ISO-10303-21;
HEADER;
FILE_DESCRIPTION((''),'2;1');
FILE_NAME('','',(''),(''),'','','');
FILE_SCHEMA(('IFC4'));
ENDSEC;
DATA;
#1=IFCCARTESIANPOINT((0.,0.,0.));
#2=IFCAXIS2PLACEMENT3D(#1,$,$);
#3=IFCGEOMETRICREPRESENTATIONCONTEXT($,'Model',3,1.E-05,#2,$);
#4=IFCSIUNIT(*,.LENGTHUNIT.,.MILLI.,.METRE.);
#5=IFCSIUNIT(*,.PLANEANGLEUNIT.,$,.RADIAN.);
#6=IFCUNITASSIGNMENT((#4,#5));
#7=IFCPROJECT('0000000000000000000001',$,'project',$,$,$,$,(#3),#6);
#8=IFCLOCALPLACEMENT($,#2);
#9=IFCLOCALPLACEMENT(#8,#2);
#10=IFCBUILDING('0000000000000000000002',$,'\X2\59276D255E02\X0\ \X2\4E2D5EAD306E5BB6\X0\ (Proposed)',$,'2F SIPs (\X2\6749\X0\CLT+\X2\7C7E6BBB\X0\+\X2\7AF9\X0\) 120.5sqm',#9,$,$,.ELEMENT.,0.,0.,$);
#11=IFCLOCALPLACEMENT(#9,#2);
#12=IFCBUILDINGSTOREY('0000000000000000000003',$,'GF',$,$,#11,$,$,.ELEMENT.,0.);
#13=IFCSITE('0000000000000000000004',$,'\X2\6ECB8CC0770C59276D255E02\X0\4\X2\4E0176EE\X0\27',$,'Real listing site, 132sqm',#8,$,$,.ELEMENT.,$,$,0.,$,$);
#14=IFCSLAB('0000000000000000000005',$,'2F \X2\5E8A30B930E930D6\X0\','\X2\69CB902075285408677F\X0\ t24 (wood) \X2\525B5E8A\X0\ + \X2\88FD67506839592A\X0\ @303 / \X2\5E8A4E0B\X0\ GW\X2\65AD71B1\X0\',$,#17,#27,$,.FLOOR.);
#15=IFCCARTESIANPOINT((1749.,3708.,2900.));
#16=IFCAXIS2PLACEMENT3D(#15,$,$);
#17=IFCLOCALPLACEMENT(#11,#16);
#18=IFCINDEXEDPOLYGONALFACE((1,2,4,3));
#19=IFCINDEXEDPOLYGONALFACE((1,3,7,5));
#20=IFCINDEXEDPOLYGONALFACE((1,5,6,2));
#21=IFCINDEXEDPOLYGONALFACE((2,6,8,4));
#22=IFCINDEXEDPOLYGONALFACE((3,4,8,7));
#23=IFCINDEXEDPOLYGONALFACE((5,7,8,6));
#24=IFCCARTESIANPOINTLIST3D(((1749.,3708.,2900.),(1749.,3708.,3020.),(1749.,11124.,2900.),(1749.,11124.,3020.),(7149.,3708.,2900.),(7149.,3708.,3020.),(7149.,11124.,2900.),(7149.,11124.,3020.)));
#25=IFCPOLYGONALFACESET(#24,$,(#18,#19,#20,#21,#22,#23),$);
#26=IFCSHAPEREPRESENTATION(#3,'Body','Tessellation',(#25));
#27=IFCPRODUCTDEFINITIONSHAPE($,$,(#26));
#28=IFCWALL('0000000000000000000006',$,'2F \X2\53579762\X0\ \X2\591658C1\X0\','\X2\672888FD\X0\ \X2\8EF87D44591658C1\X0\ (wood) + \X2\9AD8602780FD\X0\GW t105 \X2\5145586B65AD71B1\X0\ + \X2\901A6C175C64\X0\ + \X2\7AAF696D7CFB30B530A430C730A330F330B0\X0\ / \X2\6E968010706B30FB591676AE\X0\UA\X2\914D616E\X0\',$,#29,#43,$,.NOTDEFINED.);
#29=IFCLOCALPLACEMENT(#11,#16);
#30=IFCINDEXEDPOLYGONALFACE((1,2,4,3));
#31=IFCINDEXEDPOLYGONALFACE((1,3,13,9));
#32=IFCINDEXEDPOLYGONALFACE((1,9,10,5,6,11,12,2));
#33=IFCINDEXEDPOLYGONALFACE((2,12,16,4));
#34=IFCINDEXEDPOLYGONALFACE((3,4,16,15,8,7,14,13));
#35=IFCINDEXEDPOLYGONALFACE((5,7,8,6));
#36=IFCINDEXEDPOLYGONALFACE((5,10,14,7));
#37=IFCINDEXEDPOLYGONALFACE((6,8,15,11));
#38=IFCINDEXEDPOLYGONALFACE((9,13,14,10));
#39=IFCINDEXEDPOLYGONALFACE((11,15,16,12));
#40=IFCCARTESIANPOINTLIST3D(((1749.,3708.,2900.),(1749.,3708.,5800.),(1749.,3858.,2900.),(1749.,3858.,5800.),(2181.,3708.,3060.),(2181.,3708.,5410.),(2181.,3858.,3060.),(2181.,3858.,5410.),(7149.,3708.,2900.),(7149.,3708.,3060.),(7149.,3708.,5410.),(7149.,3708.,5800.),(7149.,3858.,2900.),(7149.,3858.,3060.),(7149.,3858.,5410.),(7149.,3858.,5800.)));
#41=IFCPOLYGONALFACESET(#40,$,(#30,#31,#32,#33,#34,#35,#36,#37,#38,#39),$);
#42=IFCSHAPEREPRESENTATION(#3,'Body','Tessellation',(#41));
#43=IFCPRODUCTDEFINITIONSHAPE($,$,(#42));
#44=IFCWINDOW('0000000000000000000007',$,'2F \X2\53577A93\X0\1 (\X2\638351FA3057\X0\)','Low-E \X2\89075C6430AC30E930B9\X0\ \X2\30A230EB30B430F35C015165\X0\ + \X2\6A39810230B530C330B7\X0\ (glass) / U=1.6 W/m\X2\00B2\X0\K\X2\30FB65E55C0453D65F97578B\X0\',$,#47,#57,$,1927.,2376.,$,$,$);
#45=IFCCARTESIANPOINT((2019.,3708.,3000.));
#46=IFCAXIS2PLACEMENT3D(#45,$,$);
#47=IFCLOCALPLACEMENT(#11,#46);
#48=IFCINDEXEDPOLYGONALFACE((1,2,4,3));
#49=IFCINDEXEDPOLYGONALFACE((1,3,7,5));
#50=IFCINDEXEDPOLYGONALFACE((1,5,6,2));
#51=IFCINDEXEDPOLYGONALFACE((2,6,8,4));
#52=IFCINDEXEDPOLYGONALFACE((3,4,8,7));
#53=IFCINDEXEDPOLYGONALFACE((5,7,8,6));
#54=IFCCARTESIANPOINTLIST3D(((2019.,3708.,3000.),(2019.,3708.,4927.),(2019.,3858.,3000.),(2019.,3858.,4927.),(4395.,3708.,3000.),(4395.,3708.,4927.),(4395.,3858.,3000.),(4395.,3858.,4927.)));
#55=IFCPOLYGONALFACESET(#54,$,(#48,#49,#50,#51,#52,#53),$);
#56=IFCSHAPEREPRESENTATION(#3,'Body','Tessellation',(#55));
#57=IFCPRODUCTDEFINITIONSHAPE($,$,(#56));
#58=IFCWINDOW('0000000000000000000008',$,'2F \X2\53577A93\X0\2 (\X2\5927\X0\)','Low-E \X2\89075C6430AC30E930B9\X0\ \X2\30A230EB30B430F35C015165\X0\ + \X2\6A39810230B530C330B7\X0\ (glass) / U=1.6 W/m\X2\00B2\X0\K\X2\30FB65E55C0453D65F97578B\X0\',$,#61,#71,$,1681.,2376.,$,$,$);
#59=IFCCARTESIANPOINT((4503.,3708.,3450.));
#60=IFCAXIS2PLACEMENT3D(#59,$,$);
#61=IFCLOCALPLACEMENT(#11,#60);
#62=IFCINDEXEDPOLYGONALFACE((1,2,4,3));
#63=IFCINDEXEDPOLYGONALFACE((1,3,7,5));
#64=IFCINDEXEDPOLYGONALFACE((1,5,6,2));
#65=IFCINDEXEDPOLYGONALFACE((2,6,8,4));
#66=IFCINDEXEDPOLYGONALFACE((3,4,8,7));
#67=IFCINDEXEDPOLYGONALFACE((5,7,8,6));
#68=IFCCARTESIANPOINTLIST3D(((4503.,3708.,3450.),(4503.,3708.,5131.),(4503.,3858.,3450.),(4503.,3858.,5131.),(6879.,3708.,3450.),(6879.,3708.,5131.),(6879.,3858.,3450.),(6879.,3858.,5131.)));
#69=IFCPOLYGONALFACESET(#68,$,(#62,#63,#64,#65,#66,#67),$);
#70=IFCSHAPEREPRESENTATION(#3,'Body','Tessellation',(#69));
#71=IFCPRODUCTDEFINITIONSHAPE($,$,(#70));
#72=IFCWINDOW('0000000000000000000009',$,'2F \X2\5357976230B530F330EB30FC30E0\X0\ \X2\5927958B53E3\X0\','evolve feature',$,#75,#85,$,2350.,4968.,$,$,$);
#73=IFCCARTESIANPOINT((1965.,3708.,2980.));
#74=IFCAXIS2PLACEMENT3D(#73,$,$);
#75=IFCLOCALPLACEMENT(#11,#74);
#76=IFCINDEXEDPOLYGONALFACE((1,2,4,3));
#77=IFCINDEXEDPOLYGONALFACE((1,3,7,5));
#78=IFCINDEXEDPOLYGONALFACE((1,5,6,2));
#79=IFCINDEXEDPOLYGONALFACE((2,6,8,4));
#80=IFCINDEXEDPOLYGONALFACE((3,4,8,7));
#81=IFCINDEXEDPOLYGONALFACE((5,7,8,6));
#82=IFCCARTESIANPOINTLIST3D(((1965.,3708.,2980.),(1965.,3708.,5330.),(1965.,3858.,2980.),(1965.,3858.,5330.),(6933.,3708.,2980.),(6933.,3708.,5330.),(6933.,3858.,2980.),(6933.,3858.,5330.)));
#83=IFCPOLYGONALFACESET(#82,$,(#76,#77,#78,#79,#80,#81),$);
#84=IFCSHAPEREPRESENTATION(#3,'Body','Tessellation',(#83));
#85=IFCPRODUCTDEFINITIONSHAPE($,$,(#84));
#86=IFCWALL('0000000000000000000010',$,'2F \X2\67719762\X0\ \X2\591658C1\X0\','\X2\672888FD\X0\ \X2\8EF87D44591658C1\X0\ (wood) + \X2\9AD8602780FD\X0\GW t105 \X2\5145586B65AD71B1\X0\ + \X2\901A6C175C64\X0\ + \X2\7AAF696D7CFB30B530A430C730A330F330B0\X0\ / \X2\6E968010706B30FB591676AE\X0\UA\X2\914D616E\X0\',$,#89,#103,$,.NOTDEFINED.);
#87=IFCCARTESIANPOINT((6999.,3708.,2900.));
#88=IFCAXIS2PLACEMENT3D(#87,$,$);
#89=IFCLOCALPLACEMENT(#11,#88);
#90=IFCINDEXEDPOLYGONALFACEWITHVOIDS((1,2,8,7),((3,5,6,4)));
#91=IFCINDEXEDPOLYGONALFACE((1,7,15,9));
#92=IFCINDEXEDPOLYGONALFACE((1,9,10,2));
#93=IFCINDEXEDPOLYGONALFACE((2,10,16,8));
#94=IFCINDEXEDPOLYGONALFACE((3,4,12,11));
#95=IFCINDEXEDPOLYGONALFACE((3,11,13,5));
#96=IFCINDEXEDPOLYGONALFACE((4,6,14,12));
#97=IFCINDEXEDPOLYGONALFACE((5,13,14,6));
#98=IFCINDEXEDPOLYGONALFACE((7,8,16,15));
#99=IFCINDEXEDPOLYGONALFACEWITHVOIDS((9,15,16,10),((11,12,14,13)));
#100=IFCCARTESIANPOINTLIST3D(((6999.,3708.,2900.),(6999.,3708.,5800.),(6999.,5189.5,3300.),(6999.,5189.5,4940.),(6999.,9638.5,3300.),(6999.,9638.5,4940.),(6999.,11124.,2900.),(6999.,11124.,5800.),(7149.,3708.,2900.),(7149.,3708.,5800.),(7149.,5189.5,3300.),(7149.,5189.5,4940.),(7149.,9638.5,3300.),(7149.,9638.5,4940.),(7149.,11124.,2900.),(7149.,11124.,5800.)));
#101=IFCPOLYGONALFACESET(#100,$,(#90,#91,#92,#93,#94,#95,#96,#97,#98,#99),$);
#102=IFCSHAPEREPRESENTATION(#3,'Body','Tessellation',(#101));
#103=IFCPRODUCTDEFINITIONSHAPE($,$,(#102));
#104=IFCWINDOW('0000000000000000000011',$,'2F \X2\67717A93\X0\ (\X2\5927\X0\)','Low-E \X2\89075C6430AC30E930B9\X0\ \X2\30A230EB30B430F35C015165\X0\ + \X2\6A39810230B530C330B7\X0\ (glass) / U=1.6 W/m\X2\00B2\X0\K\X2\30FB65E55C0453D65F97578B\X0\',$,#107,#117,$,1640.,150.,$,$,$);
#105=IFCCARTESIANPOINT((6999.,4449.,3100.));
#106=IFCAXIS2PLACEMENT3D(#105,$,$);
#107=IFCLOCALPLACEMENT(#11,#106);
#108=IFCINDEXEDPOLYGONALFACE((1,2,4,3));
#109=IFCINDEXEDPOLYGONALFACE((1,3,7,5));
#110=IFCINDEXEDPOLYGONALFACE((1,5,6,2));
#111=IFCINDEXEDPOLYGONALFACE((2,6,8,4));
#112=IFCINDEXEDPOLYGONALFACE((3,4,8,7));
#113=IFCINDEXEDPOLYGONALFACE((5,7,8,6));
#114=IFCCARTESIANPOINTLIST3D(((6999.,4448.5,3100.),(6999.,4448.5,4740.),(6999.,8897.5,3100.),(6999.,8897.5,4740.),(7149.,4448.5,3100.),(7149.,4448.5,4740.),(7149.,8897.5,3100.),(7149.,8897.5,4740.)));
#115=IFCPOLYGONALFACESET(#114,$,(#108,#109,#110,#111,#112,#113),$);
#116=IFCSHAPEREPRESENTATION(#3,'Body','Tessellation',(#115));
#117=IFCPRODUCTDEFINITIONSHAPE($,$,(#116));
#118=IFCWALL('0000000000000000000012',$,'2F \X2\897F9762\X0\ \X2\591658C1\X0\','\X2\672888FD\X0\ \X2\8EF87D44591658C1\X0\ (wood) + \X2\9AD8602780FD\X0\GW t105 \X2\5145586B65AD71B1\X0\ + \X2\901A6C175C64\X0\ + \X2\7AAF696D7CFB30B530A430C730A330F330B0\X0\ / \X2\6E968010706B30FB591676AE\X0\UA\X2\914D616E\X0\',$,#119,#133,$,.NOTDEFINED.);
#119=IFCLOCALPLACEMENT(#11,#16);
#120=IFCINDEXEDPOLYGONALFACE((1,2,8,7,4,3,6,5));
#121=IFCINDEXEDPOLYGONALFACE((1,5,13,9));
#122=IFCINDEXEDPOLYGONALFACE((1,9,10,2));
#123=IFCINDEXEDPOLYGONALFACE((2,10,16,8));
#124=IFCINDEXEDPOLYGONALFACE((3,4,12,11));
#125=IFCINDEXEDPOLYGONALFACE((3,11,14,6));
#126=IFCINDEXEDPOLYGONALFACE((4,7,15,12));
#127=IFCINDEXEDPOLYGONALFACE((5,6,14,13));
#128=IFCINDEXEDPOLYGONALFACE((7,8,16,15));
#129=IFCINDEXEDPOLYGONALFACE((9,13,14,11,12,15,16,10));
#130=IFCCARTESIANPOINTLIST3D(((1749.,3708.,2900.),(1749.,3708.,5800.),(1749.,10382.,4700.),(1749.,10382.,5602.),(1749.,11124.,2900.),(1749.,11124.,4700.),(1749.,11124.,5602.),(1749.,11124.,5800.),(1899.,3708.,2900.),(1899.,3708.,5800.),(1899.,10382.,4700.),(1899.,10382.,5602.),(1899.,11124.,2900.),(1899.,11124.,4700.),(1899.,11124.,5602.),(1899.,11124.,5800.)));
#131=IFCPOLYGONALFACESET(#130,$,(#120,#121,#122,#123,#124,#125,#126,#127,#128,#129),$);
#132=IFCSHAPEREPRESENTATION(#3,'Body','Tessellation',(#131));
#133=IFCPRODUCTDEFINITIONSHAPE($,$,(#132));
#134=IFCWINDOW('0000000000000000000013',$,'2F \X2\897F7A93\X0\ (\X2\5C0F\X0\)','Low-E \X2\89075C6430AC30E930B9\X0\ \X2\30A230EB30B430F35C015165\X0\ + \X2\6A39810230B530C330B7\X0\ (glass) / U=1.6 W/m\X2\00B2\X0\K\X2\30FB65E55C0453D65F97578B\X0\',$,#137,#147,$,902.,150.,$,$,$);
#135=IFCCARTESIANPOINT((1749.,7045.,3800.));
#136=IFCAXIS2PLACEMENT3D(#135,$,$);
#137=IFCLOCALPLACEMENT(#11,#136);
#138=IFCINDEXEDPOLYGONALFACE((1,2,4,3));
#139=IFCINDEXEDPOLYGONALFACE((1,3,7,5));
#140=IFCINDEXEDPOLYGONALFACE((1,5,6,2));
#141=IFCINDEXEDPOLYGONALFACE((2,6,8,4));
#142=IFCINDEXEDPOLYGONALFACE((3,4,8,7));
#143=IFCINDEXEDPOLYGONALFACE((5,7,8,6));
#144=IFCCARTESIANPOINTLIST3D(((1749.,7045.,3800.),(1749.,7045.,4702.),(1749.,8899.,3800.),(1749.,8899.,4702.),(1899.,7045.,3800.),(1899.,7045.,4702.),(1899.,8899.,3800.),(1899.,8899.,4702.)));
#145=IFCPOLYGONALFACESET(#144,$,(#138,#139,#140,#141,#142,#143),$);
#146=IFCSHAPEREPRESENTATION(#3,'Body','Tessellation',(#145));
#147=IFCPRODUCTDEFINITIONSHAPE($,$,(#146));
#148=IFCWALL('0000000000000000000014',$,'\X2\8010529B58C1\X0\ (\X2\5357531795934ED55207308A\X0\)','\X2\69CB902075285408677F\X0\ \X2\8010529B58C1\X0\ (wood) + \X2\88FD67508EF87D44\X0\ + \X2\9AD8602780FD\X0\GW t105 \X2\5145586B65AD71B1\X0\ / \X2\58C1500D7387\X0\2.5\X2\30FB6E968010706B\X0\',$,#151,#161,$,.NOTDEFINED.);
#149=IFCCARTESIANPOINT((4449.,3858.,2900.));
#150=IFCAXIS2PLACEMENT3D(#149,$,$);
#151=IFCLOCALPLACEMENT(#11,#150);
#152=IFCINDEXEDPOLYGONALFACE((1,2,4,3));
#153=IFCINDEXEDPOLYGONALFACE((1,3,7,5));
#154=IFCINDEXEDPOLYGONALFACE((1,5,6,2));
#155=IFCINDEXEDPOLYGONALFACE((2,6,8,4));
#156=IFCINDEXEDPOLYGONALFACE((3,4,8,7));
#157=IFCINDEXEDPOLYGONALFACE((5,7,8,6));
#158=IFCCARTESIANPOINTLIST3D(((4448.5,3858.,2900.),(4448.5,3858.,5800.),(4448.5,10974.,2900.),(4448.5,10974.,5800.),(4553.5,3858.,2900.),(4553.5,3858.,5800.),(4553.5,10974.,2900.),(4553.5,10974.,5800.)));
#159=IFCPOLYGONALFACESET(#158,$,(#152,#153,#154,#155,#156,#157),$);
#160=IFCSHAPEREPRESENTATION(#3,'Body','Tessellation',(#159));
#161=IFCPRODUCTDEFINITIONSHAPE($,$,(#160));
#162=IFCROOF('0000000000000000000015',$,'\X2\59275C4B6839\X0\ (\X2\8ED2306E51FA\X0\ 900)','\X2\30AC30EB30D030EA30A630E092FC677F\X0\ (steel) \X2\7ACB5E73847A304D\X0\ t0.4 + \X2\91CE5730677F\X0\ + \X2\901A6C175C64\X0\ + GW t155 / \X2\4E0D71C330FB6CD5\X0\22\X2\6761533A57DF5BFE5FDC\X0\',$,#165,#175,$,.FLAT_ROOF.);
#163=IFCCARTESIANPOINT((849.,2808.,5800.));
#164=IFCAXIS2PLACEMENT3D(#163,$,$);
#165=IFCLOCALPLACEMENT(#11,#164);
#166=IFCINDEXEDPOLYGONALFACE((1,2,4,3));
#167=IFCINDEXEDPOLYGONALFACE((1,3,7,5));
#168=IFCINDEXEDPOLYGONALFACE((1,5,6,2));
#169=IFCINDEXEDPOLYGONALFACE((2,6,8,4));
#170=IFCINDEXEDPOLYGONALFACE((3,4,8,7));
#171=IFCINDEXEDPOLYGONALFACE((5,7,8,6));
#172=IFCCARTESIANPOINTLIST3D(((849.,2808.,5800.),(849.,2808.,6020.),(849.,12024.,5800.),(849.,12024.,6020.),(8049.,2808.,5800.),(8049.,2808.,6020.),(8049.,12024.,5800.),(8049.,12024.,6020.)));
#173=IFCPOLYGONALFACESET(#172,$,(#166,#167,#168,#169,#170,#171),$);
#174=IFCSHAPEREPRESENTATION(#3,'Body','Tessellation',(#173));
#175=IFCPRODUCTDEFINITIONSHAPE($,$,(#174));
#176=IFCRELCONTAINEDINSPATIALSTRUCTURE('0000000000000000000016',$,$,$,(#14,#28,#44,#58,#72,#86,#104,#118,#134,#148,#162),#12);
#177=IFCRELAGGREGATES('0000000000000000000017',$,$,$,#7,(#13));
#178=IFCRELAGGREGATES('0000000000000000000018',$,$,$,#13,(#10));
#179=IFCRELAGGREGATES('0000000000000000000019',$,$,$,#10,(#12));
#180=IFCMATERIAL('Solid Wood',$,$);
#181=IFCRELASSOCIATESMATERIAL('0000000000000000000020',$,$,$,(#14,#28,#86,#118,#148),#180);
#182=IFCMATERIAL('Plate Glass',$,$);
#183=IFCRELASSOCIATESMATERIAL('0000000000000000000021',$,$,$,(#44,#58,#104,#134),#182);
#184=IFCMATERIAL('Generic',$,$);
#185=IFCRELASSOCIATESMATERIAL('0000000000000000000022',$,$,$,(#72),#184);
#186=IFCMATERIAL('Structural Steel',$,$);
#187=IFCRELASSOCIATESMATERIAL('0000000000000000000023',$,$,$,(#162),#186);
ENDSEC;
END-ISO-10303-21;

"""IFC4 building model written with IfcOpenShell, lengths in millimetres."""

from ifc_helpers import new_model, si_unit, frame, frame_2d, origin, place, context, project, spatial, rectangle, extrude, material, element, fill, save


model = new_model("IFC4")

# Units and contexts
model_context = context("Model", 3, precision=1e-05, world=origin())
ifc_project = project(units=[si_unit("LENGTHUNIT", "METRE", prefix="MILLI"), si_unit("PLANEANGLEUNIT", "RADIAN")], contexts=[model_context])

# Site, building, storey
site_placement = place(None, origin())
site = spatial("IfcSite", under=ifc_project, at=site_placement, Name="滋賀県大津市4丁目27", ObjectType="Real listing site, 132sqm", CompositionType="ELEMENT", RefElevation=0.0)
building_placement = place(site_placement, origin())
building = spatial("IfcBuilding", under=site, at=building_placement, Name="大津市 中庭の家 (Proposed)", ObjectType="2F SIPs (杉CLT+籾殻+竹) 120.5sqm", CompositionType="ELEMENT", ElevationOfRefHeight=0.0, ElevationOfTerrain=0.0)
storey_placement = place(building_placement, origin())
storey = spatial("IfcBuildingStorey", under=building, at=storey_placement, Name="GF", CompositionType="ELEMENT", Elevation=0.0)

# Slab
ifc_material_1 = material(Name="Solid Wood")
slab_placement = place(storey_placement, frame((1749.0, 3708.0, 2900.0)))
element("IfcSlab", 1, at=slab_placement, inside=storey, material=ifc_material_1, Name="2F 床スラブ", Description="構造用合板 t24 (wood) 剛床 + 製材根太 @303 / 床下 GW断熱", PredefinedType="FLOOR", context=model_context, shape_type="SweptSolid", body=[
    extrude(rectangle(XDim=5400.0, YDim=7416.0, at=frame_2d((2700.0, 3708.0))), frame((1749.0, 3708.0, 2900.0)), (0.0, 0.0, 1.0), 120.0),
])

# Wall, openings, windows
wall_1_placement = place(storey_placement, frame((1749.0, 3708.0, 2900.0)))
wall_1 = element("IfcWall", 2, at=wall_1_placement, inside=storey, material=ifc_material_1, Name="2F 南面 外壁", Description="木製 軸組外壁 (wood) + 高性能GW t105 充填断熱 + 通気層 + 窯業系サイディング / 準耐火・外皮UA配慮", PredefinedType="NOTDEFINED", context=model_context, shape_type="SweptSolid", body=[
    extrude(rectangle(XDim=5400.0, YDim=150.0, at=frame_2d((2700.0, 75.0))), frame((1749.0, 3708.0, 2900.0)), (0.0, 0.0, 1.0), 2900.0),
])
opening_1_placement = place(storey_placement, frame((2019.0, 3708.0, 3000.0)))
opening_1 = element("IfcOpeningElement", 3, at=opening_1_placement, cuts=wall_1, PredefinedType="NOTDEFINED", context=model_context, shape_type="SweptSolid", body=[
    extrude(rectangle(XDim=2376.0, YDim=150.0, at=frame_2d((1188.0, 75.0))), frame((2019.0, 3708.0, 3000.0)), (0.0, 0.0, 1.0), 1927.0),
])
opening_2_placement = place(storey_placement, frame((4503.0, 3708.0, 3450.0)))
opening_2 = element("IfcOpeningElement", 4, at=opening_2_placement, cuts=wall_1, PredefinedType="NOTDEFINED", context=model_context, shape_type="SweptSolid", body=[
    extrude(rectangle(XDim=2376.0, YDim=150.0, at=frame_2d((1188.0, 75.0))), frame((4503.0, 3708.0, 3450.0)), (0.0, 0.0, 1.0), 1681.0),
])
opening_3_placement = place(storey_placement, frame((1965.0, 3708.0, 2980.0)))
opening_3 = element("IfcOpeningElement", 5, at=opening_3_placement, cuts=wall_1, PredefinedType="NOTDEFINED", context=model_context, shape_type="SweptSolid", body=[
    extrude(rectangle(XDim=4968.0, YDim=150.0, at=frame_2d((2484.0, 75.0))), frame((1965.0, 3708.0, 2980.0)), (0.0, 0.0, 1.0), 2350.0),
])
ifc_material_2 = material(Name="Plate Glass")
window_1_placement = place(storey_placement, frame((2019.0, 3708.0, 3000.0)))
window_1 = element("IfcWindow", 6, at=window_1_placement, inside=storey, material=ifc_material_2, Name="2F 南窓1 (掃出し)", Description="Low-E 複層ガラス アルゴン封入 + 樹脂サッシ (glass) / U=1.6 W/m²K・日射取得型", OverallHeight=1927.0, OverallWidth=2376.0, context=model_context, shape_type="SweptSolid", body=[
    extrude(rectangle(XDim=2376.0, YDim=150.0, at=frame_2d((1188.0, 75.0))), frame((2019.0, 3708.0, 3000.0)), (0.0, 0.0, 1.0), 1927.0),
])
fill(opening_1, window_1)
window_2_placement = place(storey_placement, frame((4503.0, 3708.0, 3450.0)))
window_2 = element("IfcWindow", 7, at=window_2_placement, inside=storey, material=ifc_material_2, Name="2F 南窓2 (大)", Description="Low-E 複層ガラス アルゴン封入 + 樹脂サッシ (glass) / U=1.6 W/m²K・日射取得型", OverallHeight=1681.0, OverallWidth=2376.0, context=model_context, shape_type="SweptSolid", body=[
    extrude(rectangle(XDim=2376.0, YDim=150.0, at=frame_2d((1188.0, 75.0))), frame((4503.0, 3708.0, 3450.0)), (0.0, 0.0, 1.0), 1681.0),
])
fill(opening_2, window_2)
ifc_material_3 = material(Name="Generic")
window_3_placement = place(storey_placement, frame((1965.0, 3708.0, 2980.0)))
window_3 = element("IfcWindow", 8, at=window_3_placement, inside=storey, material=ifc_material_3, Name="2F 南面サンルーム 大開口", Description="evolve feature", OverallHeight=2350.0, OverallWidth=4968.0, context=model_context, shape_type="SweptSolid", body=[
    extrude(rectangle(XDim=4968.0, YDim=150.0, at=frame_2d((2484.0, 75.0))), frame((1965.0, 3708.0, 2980.0)), (0.0, 0.0, 1.0), 2350.0),
])
fill(opening_3, window_3)

# Walls, openings, windows
wall_2_placement = place(storey_placement, frame((6999.0, 3708.0, 2900.0)))
wall_2 = element("IfcWall", 9, at=wall_2_placement, inside=storey, material=ifc_material_1, Name="2F 東面 外壁", Description="木製 軸組外壁 (wood) + 高性能GW t105 充填断熱 + 通気層 + 窯業系サイディング / 準耐火・外皮UA配慮", PredefinedType="NOTDEFINED", context=model_context, shape_type="SweptSolid", body=[
    extrude(rectangle(XDim=150.0, YDim=7416.0, at=frame_2d((75.0, 3708.0))), frame((6999.0, 3708.0, 2900.0)), (0.0, 0.0, 1.0), 2900.0),
])
opening_4_placement = place(storey_placement, frame((6999.0, 4449.0, 3100.0)))
opening_4 = element("IfcOpeningElement", 10, at=opening_4_placement, cuts=wall_2, PredefinedType="NOTDEFINED", context=model_context, shape_type="SweptSolid", body=[
    extrude(rectangle(XDim=150.0, YDim=4449.0, at=frame_2d((75.0, 2224.0))), frame((6999.0, 4449.0, 3100.0)), (0.0, 0.0, 1.0), 1640.0),
])
window_4_placement = place(storey_placement, frame((6999.0, 4449.0, 3100.0)))
window_4 = element("IfcWindow", 11, at=window_4_placement, inside=storey, material=ifc_material_2, Name="2F 東窓 (大)", Description="Low-E 複層ガラス アルゴン封入 + 樹脂サッシ (glass) / U=1.6 W/m²K・日射取得型", OverallHeight=1640.0, OverallWidth=150.0, context=model_context, shape_type="SweptSolid", body=[
    extrude(rectangle(XDim=150.0, YDim=4449.0, at=frame_2d((75.0, 2224.0))), frame((6999.0, 4449.0, 3100.0)), (0.0, 0.0, 1.0), 1640.0),
])
fill(opening_4, window_4)
wall_3_placement = place(storey_placement, frame((1749.0, 3708.0, 2900.0)))
wall_3 = element("IfcWall", 12, at=wall_3_placement, inside=storey, material=ifc_material_1, Name="2F 西面 外壁", Description="木製 軸組外壁 (wood) + 高性能GW t105 充填断熱 + 通気層 + 窯業系サイディング / 準耐火・外皮UA配慮", PredefinedType="NOTDEFINED", context=model_context, shape_type="SweptSolid", body=[
    extrude(rectangle(XDim=150.0, YDim=7416.0, at=frame_2d((75.0, 3708.0))), frame((1749.0, 3708.0, 2900.0)), (0.0, 0.0, 1.0), 2900.0),
])
opening_5_placement = place(storey_placement, frame((1749.0, 7045.0, 3800.0)))
opening_5 = element("IfcOpeningElement", 13, at=opening_5_placement, cuts=wall_3, PredefinedType="NOTDEFINED", context=model_context, shape_type="SweptSolid", body=[
    extrude(rectangle(XDim=150.0, YDim=1854.0, at=frame_2d((75.0, 927.0))), frame((1749.0, 7045.0, 3800.0)), (0.0, 0.0, 1.0), 902.0),
])
window_5_placement = place(storey_placement, frame((1749.0, 7045.0, 3800.0)))
window_5 = element("IfcWindow", 14, at=window_5_placement, inside=storey, material=ifc_material_2, Name="2F 西窓 (小)", Description="Low-E 複層ガラス アルゴン封入 + 樹脂サッシ (glass) / U=1.6 W/m²K・日射取得型", OverallHeight=902.0, OverallWidth=150.0, context=model_context, shape_type="SweptSolid", body=[
    extrude(rectangle(XDim=150.0, YDim=1854.0, at=frame_2d((75.0, 927.0))), frame((1749.0, 7045.0, 3800.0)), (0.0, 0.0, 1.0), 902.0),
])
fill(opening_5, window_5)

# Wall
wall_4_placement = place(storey_placement, frame((4449.0, 3858.0, 2900.0)))
element("IfcWall", 15, at=wall_4_placement, inside=storey, material=ifc_material_1, Name="耐力壁 (南北間仕切り)", Description="構造用合板 耐力壁 (wood) + 製材軸組 + 高性能GW t105 充填断熱 / 壁倍率2.5・準耐火", PredefinedType="NOTDEFINED", context=model_context, shape_type="SweptSolid", body=[
    extrude(rectangle(XDim=105.0, YDim=7116.0, at=frame_2d((52.0, 3558.0))), frame((4449.0, 3858.0, 2900.0)), (0.0, 0.0, 1.0), 2900.0),
])

# Roof
ifc_material_4 = material(Name="Structural Steel")
roof_1_placement = place(storey_placement, frame((849.0, 2808.0, 5800.0)))
element("IfcRoof", 16, at=roof_1_placement, inside=storey, material=ifc_material_4, Name="大屋根 (軒の出 900)", Description="ガルバリウム鋼板 (steel) 立平葺き t0.4 + 野地板 + 通気層 + GW t155 / 不燃・法22条区域対応", PredefinedType="FLAT_ROOF", context=model_context, shape_type="SweptSolid", body=[
    extrude(rectangle(XDim=7200.0, YDim=9216.0, at=frame_2d((3600.0, 4608.0))), frame((849.0, 2808.0, 5800.0)), (0.0, 0.0, 1.0), 220.0),
])

save(model, "model.ifc")
